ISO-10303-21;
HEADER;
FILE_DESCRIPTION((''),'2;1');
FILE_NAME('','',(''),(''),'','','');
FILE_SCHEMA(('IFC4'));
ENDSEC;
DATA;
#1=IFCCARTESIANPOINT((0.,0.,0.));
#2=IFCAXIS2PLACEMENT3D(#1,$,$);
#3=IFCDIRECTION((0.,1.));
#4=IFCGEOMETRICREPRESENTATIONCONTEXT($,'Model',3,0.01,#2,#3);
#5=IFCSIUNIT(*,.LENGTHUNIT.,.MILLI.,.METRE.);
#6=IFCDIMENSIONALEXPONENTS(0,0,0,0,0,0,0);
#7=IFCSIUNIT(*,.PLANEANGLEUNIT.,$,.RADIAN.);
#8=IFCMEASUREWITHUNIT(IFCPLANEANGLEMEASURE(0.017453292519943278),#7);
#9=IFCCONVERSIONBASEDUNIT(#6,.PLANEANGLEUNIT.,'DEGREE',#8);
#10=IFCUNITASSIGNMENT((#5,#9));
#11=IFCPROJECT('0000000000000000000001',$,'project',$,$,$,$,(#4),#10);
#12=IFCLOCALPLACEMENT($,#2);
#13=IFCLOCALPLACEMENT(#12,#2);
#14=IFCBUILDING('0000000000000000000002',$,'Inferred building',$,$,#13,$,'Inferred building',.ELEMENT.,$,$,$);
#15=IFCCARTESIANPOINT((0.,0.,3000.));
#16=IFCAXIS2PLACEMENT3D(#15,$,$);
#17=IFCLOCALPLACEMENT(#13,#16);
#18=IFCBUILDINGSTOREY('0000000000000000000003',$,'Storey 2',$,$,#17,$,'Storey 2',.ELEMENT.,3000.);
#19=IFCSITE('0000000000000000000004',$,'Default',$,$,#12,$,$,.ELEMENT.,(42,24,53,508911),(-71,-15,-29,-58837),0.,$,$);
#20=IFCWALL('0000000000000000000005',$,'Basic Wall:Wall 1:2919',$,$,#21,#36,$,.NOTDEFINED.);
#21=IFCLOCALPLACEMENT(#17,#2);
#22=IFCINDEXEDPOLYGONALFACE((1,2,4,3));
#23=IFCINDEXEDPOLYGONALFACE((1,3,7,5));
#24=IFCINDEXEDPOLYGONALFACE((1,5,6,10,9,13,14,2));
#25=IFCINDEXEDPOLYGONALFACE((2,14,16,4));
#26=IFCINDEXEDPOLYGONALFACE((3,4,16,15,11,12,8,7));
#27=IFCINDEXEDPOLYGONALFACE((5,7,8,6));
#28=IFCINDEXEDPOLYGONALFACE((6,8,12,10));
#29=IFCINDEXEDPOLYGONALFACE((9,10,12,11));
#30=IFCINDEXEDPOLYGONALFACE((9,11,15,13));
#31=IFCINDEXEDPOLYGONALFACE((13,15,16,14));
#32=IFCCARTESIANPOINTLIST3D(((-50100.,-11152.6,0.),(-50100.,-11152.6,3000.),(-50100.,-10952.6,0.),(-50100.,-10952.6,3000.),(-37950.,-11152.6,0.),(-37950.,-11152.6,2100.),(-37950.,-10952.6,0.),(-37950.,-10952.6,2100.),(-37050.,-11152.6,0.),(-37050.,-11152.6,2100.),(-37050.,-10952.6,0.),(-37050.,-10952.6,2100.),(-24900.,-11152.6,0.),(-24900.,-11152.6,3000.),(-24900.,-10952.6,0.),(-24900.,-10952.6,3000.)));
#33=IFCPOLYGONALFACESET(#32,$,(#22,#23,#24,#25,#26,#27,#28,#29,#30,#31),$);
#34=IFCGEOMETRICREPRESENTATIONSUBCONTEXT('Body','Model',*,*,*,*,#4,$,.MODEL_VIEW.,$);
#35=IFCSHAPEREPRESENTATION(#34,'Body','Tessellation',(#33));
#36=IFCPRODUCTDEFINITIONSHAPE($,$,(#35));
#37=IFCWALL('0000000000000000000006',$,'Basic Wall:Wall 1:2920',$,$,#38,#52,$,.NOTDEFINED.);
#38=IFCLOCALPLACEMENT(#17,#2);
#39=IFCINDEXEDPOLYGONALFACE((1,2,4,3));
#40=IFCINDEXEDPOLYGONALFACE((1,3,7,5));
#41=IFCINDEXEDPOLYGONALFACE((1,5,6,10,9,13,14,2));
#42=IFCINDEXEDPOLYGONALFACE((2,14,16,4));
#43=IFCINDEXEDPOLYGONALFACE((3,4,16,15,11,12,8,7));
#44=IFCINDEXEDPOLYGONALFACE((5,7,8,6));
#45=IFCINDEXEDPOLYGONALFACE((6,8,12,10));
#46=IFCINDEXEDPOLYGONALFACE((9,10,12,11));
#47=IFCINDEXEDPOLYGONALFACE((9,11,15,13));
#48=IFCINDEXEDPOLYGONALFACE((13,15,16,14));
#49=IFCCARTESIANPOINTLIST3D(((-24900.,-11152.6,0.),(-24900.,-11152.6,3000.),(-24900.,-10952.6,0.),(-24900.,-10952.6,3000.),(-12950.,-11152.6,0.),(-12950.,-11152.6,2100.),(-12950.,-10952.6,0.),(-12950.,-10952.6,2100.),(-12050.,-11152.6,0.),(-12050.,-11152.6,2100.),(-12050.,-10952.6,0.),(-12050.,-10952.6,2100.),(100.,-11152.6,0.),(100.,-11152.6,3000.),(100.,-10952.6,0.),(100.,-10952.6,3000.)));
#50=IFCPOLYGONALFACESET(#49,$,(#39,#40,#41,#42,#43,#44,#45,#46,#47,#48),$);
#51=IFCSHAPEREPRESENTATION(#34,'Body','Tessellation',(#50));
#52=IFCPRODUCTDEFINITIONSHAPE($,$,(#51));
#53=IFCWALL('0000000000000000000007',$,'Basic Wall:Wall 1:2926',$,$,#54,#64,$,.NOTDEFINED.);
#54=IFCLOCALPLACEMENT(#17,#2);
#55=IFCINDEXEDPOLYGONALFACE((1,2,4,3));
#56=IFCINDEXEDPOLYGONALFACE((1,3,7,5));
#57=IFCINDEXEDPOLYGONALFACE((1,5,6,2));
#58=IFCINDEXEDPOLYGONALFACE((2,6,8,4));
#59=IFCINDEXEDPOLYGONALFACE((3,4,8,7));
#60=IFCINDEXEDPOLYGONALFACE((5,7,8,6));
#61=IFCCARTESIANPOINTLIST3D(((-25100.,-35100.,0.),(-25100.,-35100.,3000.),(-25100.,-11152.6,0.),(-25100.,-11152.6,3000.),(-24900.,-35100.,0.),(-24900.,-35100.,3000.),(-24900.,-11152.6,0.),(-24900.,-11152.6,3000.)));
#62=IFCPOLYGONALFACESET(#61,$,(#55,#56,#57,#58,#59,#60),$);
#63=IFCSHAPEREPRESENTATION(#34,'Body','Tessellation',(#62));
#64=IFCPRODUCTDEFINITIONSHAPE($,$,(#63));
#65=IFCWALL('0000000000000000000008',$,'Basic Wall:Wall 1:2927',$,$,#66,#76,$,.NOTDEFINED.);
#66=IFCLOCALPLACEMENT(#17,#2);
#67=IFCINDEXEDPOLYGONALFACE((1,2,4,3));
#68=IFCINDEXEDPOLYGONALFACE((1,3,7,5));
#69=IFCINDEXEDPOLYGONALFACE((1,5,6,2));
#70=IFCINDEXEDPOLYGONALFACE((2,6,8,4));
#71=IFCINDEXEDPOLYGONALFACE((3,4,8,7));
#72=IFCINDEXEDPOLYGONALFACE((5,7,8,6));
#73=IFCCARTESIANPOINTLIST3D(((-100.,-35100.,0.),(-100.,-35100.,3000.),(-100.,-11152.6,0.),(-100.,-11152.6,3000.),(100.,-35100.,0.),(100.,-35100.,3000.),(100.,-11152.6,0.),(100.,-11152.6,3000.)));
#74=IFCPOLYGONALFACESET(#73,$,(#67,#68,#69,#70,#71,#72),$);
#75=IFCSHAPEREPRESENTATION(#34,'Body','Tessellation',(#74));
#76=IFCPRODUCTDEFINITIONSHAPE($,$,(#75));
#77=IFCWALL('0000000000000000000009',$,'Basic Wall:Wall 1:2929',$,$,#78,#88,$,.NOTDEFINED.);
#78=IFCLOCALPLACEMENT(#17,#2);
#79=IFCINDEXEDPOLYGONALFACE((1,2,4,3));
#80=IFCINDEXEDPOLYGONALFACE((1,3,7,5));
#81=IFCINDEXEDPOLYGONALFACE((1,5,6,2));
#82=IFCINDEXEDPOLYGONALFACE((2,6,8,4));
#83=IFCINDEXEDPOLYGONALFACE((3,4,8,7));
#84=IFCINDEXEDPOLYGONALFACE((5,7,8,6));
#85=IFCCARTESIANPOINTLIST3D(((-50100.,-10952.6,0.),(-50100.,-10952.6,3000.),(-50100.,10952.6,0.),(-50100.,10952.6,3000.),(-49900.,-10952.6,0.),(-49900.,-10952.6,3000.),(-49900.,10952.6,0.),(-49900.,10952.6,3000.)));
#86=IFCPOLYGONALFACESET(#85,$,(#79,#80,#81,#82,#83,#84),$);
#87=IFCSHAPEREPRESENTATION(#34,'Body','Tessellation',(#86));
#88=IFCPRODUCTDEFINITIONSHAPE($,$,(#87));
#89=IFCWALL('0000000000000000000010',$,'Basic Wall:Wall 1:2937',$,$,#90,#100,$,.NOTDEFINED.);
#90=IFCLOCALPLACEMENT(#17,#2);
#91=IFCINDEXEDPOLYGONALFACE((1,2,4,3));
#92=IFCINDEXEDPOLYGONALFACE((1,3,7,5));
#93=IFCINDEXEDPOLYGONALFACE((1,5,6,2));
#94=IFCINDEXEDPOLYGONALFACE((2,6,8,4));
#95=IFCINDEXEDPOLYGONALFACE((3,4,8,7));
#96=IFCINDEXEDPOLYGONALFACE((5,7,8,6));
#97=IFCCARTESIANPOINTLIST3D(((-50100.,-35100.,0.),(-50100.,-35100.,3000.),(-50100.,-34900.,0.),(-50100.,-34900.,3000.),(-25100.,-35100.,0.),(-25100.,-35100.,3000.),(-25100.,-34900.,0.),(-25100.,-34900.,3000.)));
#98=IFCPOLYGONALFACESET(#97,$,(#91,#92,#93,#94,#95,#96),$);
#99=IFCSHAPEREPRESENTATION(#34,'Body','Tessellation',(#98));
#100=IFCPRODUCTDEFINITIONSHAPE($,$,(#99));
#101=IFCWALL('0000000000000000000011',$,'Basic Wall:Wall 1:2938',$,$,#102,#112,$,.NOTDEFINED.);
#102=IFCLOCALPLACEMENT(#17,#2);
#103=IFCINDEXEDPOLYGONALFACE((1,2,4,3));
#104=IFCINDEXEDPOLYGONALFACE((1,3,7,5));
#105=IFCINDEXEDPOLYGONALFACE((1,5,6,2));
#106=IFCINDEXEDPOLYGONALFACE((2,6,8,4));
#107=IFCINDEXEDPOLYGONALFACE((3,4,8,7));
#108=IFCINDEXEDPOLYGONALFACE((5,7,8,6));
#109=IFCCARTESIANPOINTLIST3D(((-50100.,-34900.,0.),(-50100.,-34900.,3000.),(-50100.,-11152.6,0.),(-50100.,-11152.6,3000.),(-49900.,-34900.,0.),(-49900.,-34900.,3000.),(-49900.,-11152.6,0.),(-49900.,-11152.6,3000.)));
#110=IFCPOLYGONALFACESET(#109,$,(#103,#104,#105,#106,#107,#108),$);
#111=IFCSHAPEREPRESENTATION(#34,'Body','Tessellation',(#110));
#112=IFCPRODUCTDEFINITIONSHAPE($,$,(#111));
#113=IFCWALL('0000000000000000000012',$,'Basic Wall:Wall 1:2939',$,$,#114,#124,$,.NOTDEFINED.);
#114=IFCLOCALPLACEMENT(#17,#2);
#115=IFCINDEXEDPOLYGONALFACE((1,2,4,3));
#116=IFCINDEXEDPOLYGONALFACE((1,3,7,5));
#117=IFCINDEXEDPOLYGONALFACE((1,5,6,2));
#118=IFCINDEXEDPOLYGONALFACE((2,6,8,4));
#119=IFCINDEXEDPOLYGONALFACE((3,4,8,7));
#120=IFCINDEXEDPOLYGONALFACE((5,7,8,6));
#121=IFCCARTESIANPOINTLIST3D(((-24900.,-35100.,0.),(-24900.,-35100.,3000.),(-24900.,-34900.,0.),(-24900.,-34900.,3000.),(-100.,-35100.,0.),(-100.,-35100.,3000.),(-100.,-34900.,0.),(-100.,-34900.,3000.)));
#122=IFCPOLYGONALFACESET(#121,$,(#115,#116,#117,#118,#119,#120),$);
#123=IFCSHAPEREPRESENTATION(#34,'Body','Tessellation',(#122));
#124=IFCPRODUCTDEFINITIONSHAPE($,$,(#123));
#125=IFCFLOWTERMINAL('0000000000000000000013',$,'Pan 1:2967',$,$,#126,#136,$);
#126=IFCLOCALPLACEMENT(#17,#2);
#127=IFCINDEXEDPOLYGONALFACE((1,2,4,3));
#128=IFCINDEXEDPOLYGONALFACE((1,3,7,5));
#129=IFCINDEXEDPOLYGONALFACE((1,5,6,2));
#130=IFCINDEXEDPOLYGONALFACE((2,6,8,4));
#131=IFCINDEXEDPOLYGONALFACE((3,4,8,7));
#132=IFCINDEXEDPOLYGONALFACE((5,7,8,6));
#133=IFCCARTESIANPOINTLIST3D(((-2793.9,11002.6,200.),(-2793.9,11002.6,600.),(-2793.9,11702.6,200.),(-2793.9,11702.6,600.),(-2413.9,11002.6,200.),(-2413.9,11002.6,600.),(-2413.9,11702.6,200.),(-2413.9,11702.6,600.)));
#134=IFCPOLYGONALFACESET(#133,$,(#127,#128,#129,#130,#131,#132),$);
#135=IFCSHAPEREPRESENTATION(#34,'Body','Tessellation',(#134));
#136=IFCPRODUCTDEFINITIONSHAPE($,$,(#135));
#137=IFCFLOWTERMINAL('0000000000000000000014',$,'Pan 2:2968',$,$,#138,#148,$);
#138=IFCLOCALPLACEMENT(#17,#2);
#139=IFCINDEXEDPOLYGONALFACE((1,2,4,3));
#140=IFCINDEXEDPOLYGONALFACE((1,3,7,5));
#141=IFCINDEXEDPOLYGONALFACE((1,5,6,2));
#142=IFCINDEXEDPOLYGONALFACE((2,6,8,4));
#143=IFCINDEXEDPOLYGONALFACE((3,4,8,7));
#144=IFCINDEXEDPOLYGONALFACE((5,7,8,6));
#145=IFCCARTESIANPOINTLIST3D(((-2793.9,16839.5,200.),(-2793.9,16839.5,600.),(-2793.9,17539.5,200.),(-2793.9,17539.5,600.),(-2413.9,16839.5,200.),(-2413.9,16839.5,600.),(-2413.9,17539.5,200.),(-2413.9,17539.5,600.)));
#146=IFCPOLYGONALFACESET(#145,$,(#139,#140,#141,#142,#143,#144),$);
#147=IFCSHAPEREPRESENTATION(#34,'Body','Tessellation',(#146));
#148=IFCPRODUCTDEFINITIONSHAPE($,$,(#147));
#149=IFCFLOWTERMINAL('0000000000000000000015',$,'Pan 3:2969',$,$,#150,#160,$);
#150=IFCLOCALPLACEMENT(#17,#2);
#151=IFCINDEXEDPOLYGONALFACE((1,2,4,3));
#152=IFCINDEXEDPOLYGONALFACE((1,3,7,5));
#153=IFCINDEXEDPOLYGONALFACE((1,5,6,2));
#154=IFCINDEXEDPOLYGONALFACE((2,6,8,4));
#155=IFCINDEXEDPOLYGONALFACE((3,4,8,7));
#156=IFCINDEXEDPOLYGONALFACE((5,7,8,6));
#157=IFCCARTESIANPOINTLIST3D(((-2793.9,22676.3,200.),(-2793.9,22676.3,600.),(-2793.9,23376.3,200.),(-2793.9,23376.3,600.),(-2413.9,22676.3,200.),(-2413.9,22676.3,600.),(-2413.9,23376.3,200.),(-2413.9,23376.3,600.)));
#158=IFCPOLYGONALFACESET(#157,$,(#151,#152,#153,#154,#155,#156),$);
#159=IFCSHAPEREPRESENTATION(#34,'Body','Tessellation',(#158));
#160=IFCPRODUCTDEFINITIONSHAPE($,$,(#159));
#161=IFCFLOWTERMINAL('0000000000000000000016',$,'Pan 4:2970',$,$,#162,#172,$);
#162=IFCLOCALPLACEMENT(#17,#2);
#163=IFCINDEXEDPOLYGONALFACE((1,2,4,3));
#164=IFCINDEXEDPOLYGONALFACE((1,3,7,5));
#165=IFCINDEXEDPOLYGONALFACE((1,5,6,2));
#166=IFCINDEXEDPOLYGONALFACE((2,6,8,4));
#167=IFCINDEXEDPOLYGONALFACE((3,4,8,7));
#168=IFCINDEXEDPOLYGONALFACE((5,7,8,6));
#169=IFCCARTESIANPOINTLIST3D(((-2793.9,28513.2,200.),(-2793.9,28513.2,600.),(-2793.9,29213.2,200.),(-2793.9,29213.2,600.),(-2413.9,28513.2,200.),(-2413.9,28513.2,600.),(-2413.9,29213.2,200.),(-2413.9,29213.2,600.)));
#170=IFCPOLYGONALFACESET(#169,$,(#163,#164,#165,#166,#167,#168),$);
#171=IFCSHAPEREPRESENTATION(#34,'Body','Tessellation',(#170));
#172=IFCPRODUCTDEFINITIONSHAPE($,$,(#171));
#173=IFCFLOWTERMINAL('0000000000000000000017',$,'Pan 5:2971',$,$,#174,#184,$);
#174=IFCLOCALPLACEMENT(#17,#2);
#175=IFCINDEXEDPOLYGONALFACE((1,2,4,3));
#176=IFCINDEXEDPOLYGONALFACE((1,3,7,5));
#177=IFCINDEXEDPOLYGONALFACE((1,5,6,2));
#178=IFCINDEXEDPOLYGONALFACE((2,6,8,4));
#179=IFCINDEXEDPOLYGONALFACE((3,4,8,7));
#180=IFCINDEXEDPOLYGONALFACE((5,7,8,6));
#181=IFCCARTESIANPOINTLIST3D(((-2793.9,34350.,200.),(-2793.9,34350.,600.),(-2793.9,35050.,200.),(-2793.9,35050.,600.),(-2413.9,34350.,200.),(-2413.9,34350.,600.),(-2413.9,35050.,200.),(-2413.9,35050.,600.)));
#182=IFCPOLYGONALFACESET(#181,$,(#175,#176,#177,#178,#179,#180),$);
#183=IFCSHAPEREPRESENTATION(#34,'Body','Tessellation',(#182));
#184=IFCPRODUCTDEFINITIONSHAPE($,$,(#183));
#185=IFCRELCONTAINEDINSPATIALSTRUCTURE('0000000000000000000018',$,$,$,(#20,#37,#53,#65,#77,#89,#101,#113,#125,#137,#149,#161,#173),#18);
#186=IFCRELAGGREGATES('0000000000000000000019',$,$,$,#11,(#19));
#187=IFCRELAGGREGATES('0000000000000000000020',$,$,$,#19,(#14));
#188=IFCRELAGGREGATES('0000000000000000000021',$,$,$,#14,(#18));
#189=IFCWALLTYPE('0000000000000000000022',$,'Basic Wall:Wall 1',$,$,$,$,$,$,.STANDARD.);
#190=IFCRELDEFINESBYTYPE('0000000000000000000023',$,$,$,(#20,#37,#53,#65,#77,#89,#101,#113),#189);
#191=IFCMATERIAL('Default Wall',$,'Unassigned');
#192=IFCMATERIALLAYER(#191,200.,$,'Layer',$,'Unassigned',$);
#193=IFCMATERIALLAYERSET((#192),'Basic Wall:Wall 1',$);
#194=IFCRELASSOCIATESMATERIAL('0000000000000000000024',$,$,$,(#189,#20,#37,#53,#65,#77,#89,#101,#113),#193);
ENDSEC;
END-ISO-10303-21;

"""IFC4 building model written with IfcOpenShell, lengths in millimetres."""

from ifc_helpers import new_model, entity, si_unit, converted_unit, direction, frame, frame_2d, origin, origin_2d_with_axis, place, context, subcontext, project, spatial, rectangle, extrude, material, layer, layer_set, layer_usage, type_object, element, save


model = new_model("IFC4")

# Units and contexts
model_context = context("Model", 3, precision=0.01, world=origin(), true_north=direction((0.0, 1.0)))
body_context = subcontext(model_context, "Body", "Model", "MODEL_VIEW")
ifc_project = project(units=[si_unit("LENGTHUNIT", "METRE", prefix="MILLI"), converted_unit("PLANEANGLEUNIT", "DEGREE", entity("IfcPlaneAngleMeasure", 0.017453292519943278), si_unit("PLANEANGLEUNIT", "RADIAN"), dimensions=[0, 0, 0, 0, 0, 0, 0])], contexts=[model_context])

# Site, building, storey
site_placement = place(None, origin())
site = spatial("IfcSite", under=ifc_project, at=site_placement, Name="Default", CompositionType="ELEMENT", RefLatitude=(42, 24, 53, 508911), RefLongitude=(-71, -15, -29, -58837), RefElevation=0.0)
building_placement = place(site_placement, origin())
building = spatial("IfcBuilding", under=site, at=building_placement, Name="Inferred building", LongName="Inferred building", CompositionType="ELEMENT")
storey_placement = place(building_placement, frame((0.0, 0.0, 3000.0)))
storey = spatial("IfcBuildingStorey", under=building, at=storey_placement, Name="Storey 2", LongName="Storey 2", CompositionType="ELEMENT", Elevation=3000.0)

# Walls, openings
ifc_material = material(Name="Default Wall", Category="Unassigned")
ifc_layer = layer(ifc_material, 200.0, Name="Layer", Category="Unassigned")
ifc_layer_set = layer_set([ifc_layer], Name="Basic Wall:Wall 1")
ifc_layer_usage_1 = layer_usage(ifc_layer_set, "AXIS2", "NEGATIVE", 100.0)
wall_type = type_object("IfcWallType", Name="Basic Wall:Wall 1", PredefinedType="STANDARD", material=ifc_layer_set)
wall_1_placement = place(storey_placement, frame((-50100.0, -11052.6, 0.0)))
wall_1 = element("IfcWall", 1, at=wall_1_placement, inside=storey, type_object=wall_type, material=ifc_layer_usage_1, Name="Basic Wall:Wall 1:2919", PredefinedType="NOTDEFINED", context=body_context, shape_type="SweptSolid", body=[
    extrude(rectangle(XDim=25200.0, YDim=200.0, at=frame_2d((12600.0, 0.0), x_axis=(-1.0, 0.0))), origin(), (0.0, 0.0, 1.0), 3000.0),
])
opening_1_placement = place(wall_1_placement, origin())
element("IfcOpeningElement", 2, at=opening_1_placement, cuts=wall_1, PredefinedType="OPENING", context=body_context, shape_type="SweptSolid", body=[
    extrude(rectangle(XDim=2100.0, YDim=900.0, at=frame_2d((0.0, 0.0), x_axis=(1.0, 0.0))), frame((12600.0, -100.0, 1050.0), z_axis=(0.0, 1.0, 0.0), x_axis=(0.0, 0.0, -1.0)), (0.0, 0.0, 1.0), 200.0),
])
ifc_layer_usage_2 = layer_usage(ifc_layer_set, "AXIS2", "NEGATIVE", 100.0)
wall_2_placement = place(storey_placement, frame((-24900.0, -11052.6, 0.0)))
wall_2 = element("IfcWall", 3, at=wall_2_placement, inside=storey, type_object=wall_type, material=ifc_layer_usage_2, Name="Basic Wall:Wall 1:2920", PredefinedType="NOTDEFINED", context=body_context, shape_type="SweptSolid", body=[
    extrude(rectangle(XDim=25000.0, YDim=200.0, at=frame_2d((12500.0, 0.0), x_axis=(-1.0, 0.0))), origin(), (0.0, 0.0, 1.0), 3000.0),
])
opening_2_placement = place(wall_2_placement, origin())
element("IfcOpeningElement", 4, at=opening_2_placement, cuts=wall_2, PredefinedType="OPENING", context=body_context, shape_type="SweptSolid", body=[
    extrude(rectangle(XDim=2100.0, YDim=900.0, at=frame_2d((0.0, 0.0), x_axis=(1.0, 0.0))), frame((12400.0, -100.0, 1050.0), z_axis=(0.0, 1.0, 0.0), x_axis=(0.0, 0.0, -1.0)), (0.0, 0.0, 1.0), 200.0),
])

# Walls
ifc_layer_usage_3 = layer_usage(ifc_layer_set, "AXIS2", "NEGATIVE", 100.0)
wall_3_placement = place(storey_placement, frame((-25000.0, -35100.0, 0.0), z_axis=(0.0, 0.0, 1.0), x_axis=(0.0, 1.0, 0.0)))
element("IfcWall", 5, at=wall_3_placement, inside=storey, type_object=wall_type, material=ifc_layer_usage_3, Name="Basic Wall:Wall 1:2926", PredefinedType="NOTDEFINED", context=body_context, shape_type="SweptSolid", body=[
    extrude(rectangle(XDim=23947.4, YDim=200.0, at=frame_2d((11973.7, 0.0), x_axis=(-1.0, 0.0))), origin(), (0.0, 0.0, 1.0), 3000.0),
])
ifc_layer_usage_4 = layer_usage(ifc_layer_set, "AXIS2", "NEGATIVE", 100.0)
wall_4_placement = place(storey_placement, frame((0.0, -35100.0, 0.0), z_axis=(0.0, 0.0, 1.0), x_axis=(0.0, 1.0, 0.0)))
element("IfcWall", 6, at=wall_4_placement, inside=storey, type_object=wall_type, material=ifc_layer_usage_4, Name="Basic Wall:Wall 1:2927", PredefinedType="NOTDEFINED", context=body_context, shape_type="SweptSolid", body=[
    extrude(rectangle(XDim=23947.4, YDim=200.0, at=frame_2d((11973.7, 0.0), x_axis=(-1.0, 0.0))), origin(), (0.0, 0.0, 1.0), 3000.0),
])
ifc_layer_usage_5 = layer_usage(ifc_layer_set, "AXIS2", "NEGATIVE", 100.0)
wall_5_placement = place(storey_placement, frame((-50000.0, -10952.6, 0.0), z_axis=(0.0, 0.0, 1.0), x_axis=(0.0, 1.0, 0.0)))
element("IfcWall", 7, at=wall_5_placement, inside=storey, type_object=wall_type, material=ifc_layer_usage_5, Name="Basic Wall:Wall 1:2929", PredefinedType="NOTDEFINED", context=body_context, shape_type="SweptSolid", body=[
    extrude(rectangle(XDim=21905.3, YDim=200.0, at=frame_2d((10952.6, 0.0), x_axis=(-1.0, 0.0))), origin(), (0.0, 0.0, 1.0), 3000.0),
])
ifc_layer_usage_6 = layer_usage(ifc_layer_set, "AXIS2", "NEGATIVE", 100.0)
wall_6_placement = place(storey_placement, frame((-50100.0, -35000.0, 0.0)))
element("IfcWall", 8, at=wall_6_placement, inside=storey, type_object=wall_type, material=ifc_layer_usage_6, Name="Basic Wall:Wall 1:2937", PredefinedType="NOTDEFINED", context=body_context, shape_type="SweptSolid", body=[
    extrude(rectangle(XDim=25000.0, YDim=200.0, at=frame_2d((12500.0, 0.0), x_axis=(-1.0, 0.0))), origin(), (0.0, 0.0, 1.0), 3000.0),
])
ifc_layer_usage_7 = layer_usage(ifc_layer_set, "AXIS2", "NEGATIVE", 100.0)
wall_7_placement = place(storey_placement, frame((-50000.0, -34900.0, 0.0), z_axis=(0.0, 0.0, 1.0), x_axis=(0.0, 1.0, 0.0)))
element("IfcWall", 9, at=wall_7_placement, inside=storey, type_object=wall_type, material=ifc_layer_usage_7, Name="Basic Wall:Wall 1:2938", PredefinedType="NOTDEFINED", context=body_context, shape_type="SweptSolid", body=[
    extrude(rectangle(XDim=23747.4, YDim=200.0, at=frame_2d((11873.7, 0.0), x_axis=(-1.0, 0.0))), origin(), (0.0, 0.0, 1.0), 3000.0),
])
ifc_layer_usage_8 = layer_usage(ifc_layer_set, "AXIS2", "NEGATIVE", 100.0)
wall_8_placement = place(storey_placement, frame((-24900.0, -35000.0, 0.0)))
element("IfcWall", 10, at=wall_8_placement, inside=storey, type_object=wall_type, material=ifc_layer_usage_8, Name="Basic Wall:Wall 1:2939", PredefinedType="NOTDEFINED", context=body_context, shape_type="SweptSolid", body=[
    extrude(rectangle(XDim=24800.0, YDim=200.0, at=frame_2d((12400.0, 0.0), x_axis=(-1.0, 0.0))), origin(), (0.0, 0.0, 1.0), 3000.0),
])

# Flow terminals
flow_terminal_1_placement = place(storey_placement, origin())
element("IfcFlowTerminal", 11, at=flow_terminal_1_placement, inside=storey, Name="Pan 1:2967", context=body_context, shape_type="SweptSolid", body=[
    extrude(rectangle(XDim=700.0, YDim=380.0, at=origin_2d_with_axis()), frame((-2603.9, 11352.6, 200.0), z_axis=(0.0, 0.0, 1.0), x_axis=(0.0, 1.0, 0.0)), (0.0, 0.0, 1.0), 400.0),
])
flow_terminal_2_placement = place(storey_placement, origin())
element("IfcFlowTerminal", 12, at=flow_terminal_2_placement, inside=storey, Name="Pan 2:2968", context=body_context, shape_type="SweptSolid", body=[
    extrude(rectangle(XDim=700.0, YDim=380.0, at=origin_2d_with_axis()), frame((-2603.9, 17189.5, 200.0), z_axis=(0.0, 0.0, 1.0), x_axis=(0.0, 1.0, 0.0)), (0.0, 0.0, 1.0), 400.0),
])
flow_terminal_3_placement = place(storey_placement, origin())
element("IfcFlowTerminal", 13, at=flow_terminal_3_placement, inside=storey, Name="Pan 3:2969", context=body_context, shape_type="SweptSolid", body=[
    extrude(rectangle(XDim=700.0, YDim=380.0, at=origin_2d_with_axis()), frame((-2603.9, 23026.3, 200.0), z_axis=(0.0, 0.0, 1.0), x_axis=(0.0, 1.0, 0.0)), (0.0, 0.0, 1.0), 400.0),
])
flow_terminal_4_placement = place(storey_placement, origin())
element("IfcFlowTerminal", 14, at=flow_terminal_4_placement, inside=storey, Name="Pan 4:2970", context=body_context, shape_type="SweptSolid", body=[
    extrude(rectangle(XDim=700.0, YDim=380.0, at=origin_2d_with_axis()), frame((-2603.9, 28863.2, 200.0), z_axis=(0.0, 0.0, 1.0), x_axis=(0.0, 1.0, 0.0)), (0.0, 0.0, 1.0), 400.0),
])
flow_terminal_5_placement = place(storey_placement, origin())
element("IfcFlowTerminal", 15, at=flow_terminal_5_placement, inside=storey, Name="Pan 5:2971", context=body_context, shape_type="SweptSolid", body=[
    extrude(rectangle(XDim=700.0, YDim=380.0, at=origin_2d_with_axis()), frame((-2603.9, 34700.0, 200.0), z_axis=(0.0, 0.0, 1.0), x_axis=(0.0, 1.0, 0.0)), (0.0, 0.0, 1.0), 400.0),
])

save(model, "model.ifc")
